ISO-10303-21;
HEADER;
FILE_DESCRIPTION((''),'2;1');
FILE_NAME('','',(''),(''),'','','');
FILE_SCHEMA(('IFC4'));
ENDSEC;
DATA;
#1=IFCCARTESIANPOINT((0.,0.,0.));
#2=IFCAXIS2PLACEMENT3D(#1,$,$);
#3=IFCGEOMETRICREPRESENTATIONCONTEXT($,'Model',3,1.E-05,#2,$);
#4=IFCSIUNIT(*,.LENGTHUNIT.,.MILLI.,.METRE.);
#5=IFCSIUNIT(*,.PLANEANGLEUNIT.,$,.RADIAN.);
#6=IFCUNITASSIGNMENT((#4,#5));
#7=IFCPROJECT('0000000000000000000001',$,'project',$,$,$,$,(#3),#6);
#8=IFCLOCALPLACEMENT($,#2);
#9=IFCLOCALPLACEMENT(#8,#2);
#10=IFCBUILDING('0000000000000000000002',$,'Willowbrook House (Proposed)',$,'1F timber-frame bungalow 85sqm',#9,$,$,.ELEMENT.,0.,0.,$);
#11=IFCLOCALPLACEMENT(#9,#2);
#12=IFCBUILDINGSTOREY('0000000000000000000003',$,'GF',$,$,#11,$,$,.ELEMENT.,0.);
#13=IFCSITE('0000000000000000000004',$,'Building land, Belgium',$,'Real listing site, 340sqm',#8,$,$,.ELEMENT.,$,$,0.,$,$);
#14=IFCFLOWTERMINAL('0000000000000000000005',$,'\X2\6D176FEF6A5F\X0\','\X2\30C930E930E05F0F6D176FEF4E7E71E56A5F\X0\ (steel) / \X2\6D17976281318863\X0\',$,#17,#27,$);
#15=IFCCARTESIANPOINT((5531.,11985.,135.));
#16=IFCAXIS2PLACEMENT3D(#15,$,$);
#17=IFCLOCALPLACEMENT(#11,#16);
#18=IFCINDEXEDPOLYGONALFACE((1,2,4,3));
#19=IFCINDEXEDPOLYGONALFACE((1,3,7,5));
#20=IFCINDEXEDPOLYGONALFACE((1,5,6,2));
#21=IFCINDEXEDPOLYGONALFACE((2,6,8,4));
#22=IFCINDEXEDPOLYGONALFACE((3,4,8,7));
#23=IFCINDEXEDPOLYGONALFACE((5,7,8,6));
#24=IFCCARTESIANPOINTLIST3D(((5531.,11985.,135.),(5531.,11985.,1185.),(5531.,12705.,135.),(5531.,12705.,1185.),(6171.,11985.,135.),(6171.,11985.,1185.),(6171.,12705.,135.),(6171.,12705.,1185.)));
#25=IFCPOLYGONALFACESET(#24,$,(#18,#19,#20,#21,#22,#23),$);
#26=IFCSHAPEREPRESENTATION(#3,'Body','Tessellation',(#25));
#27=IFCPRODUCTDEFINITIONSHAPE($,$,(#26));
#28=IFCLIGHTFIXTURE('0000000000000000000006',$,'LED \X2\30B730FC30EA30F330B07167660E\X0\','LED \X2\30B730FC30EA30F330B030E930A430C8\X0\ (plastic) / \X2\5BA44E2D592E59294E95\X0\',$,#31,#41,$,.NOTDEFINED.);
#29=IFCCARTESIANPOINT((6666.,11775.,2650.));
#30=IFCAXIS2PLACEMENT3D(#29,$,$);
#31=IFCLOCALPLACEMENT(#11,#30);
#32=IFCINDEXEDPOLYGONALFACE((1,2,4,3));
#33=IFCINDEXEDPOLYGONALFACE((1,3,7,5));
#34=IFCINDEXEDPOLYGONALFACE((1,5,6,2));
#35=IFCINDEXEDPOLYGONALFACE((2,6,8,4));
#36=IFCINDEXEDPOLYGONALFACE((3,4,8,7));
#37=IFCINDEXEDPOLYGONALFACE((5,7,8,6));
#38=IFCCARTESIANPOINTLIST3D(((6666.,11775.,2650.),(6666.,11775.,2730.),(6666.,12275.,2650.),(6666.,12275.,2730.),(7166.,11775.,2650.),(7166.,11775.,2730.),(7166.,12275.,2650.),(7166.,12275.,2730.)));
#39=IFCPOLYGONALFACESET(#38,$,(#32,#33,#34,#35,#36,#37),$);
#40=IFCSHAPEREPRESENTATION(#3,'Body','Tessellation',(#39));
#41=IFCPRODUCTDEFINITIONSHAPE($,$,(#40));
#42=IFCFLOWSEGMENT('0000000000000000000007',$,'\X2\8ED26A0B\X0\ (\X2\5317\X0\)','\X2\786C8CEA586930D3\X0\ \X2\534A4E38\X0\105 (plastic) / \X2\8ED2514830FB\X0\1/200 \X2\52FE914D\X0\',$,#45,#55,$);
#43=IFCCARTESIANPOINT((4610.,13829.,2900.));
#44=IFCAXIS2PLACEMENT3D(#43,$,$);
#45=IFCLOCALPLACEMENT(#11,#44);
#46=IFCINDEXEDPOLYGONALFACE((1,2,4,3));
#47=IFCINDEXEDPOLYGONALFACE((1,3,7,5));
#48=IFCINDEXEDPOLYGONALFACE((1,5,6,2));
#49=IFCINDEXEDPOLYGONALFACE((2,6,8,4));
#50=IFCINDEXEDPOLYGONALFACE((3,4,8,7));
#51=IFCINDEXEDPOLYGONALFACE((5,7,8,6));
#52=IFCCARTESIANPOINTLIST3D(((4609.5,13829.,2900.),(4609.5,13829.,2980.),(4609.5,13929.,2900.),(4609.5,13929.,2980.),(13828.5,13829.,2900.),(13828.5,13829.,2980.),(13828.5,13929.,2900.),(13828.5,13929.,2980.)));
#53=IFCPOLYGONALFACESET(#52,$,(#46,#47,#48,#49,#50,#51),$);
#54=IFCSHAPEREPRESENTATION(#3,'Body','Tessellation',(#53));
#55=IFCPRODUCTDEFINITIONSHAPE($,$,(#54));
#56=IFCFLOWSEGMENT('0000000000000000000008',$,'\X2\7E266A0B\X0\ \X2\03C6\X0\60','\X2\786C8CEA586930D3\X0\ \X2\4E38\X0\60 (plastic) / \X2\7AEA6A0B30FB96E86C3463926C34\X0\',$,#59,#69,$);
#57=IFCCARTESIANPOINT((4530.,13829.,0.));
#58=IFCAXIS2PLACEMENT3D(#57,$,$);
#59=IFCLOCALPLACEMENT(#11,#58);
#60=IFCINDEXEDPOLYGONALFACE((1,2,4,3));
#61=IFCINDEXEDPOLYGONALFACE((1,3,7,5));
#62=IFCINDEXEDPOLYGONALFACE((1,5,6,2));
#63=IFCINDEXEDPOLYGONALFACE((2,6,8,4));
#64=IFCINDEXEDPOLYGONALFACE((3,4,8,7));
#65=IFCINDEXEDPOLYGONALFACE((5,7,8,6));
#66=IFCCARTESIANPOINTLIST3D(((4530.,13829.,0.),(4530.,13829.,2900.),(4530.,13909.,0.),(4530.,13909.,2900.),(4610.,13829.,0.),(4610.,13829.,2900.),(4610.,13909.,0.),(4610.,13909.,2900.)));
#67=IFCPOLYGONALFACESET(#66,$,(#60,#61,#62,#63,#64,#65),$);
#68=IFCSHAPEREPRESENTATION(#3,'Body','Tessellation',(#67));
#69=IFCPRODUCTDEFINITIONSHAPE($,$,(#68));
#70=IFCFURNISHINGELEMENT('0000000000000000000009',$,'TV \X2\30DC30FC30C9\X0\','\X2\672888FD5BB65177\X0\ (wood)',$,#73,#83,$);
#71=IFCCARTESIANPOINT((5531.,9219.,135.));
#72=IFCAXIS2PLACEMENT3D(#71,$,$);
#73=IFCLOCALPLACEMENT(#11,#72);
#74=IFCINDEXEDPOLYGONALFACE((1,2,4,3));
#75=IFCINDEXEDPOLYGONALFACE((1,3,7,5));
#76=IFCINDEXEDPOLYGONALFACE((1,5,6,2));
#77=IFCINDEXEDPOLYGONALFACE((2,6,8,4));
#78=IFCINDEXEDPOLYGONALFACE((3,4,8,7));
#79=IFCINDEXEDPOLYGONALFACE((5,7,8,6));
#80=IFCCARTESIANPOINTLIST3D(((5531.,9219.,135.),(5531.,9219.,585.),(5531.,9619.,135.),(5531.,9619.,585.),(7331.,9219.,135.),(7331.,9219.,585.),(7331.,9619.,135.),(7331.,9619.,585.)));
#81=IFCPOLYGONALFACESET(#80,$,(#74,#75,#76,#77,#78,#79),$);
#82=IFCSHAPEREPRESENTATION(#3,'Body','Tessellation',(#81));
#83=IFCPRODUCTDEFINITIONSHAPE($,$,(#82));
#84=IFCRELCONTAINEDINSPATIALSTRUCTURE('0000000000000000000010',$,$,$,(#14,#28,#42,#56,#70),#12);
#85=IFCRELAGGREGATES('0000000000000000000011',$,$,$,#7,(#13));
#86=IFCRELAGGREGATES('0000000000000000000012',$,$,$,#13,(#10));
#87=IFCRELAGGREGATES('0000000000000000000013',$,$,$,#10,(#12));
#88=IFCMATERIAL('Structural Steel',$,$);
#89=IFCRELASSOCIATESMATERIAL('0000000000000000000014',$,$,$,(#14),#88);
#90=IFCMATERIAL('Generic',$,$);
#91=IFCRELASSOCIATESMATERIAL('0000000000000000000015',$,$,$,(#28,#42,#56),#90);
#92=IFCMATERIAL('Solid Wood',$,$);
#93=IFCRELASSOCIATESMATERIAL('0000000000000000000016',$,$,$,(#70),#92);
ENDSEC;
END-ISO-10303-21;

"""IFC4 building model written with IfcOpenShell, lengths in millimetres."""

from ifc_helpers import new_model, si_unit, frame, frame_2d, origin, place, context, project, spatial, rectangle, extrude, material, element, save


model = new_model("IFC4")

# Units and contexts
model_context = context("Model", 3, precision=1e-05, world=origin())
ifc_project = project(units=[si_unit("LENGTHUNIT", "METRE", prefix="MILLI"), si_unit("PLANEANGLEUNIT", "RADIAN")], contexts=[model_context])

# Site, building, storey
site_placement = place(None, origin())
site = spatial("IfcSite", under=ifc_project, at=site_placement, Name="Building land, Belgium", ObjectType="Real listing site, 340sqm", CompositionType="ELEMENT", RefElevation=0.0)
building_placement = place(site_placement, origin())
building = spatial("IfcBuilding", under=site, at=building_placement, Name="Willowbrook House (Proposed)", ObjectType="1F timber-frame bungalow 85sqm", CompositionType="ELEMENT", ElevationOfRefHeight=0.0, ElevationOfTerrain=0.0)
storey_placement = place(building_placement, origin())
storey = spatial("IfcBuildingStorey", under=building, at=storey_placement, Name="GF", CompositionType="ELEMENT", Elevation=0.0)

# Shared definitions
ifc_material_1 = material(Name="Solid Wood")

# Shared definitions
ifc_material_2 = material(Name="Generic")

# Shared definitions
ifc_material_3 = material(Name="Structural Steel")

# Flow terminal
flow_terminal_placement = place(storey_placement, frame((5531.0, 11985.0, 135.0)))
element("IfcFlowTerminal", 1, at=flow_terminal_placement, inside=storey, material=ifc_material_3, Name="洗濯機", Description="ドラム式洗濯乾燥機 (steel) / 洗面脱衣", context=model_context, shape_type="SweptSolid", body=[
    extrude(rectangle(XDim=640.0, YDim=720.0, at=frame_2d((320.0, 360.0))), frame((5531.0, 11985.0, 135.0)), (0.0, 0.0, 1.0), 1050.0),
])

# Light fixture
light_fixture_placement = place(storey_placement, frame((6666.0, 11775.0, 2650.0)))
element("IfcLightFixture", 2, at=light_fixture_placement, inside=storey, material=ifc_material_2, Name="LED シーリング照明", Description="LED シーリングライト (plastic) / 室中央天井", PredefinedType="NOTDEFINED", context=model_context, shape_type="SweptSolid", body=[
    extrude(rectangle(XDim=500.0, YDim=500.0, at=frame_2d((250.0, 250.0))), frame((6666.0, 11775.0, 2650.0)), (0.0, 0.0, 1.0), 80.0),
])

# Flow segments
flow_segment_1_placement = place(storey_placement, frame((4610.0, 13829.0, 2900.0)))
element("IfcFlowSegment", 3, at=flow_segment_1_placement, inside=storey, material=ifc_material_2, Name="軒樋 (北)", Description="硬質塩ビ 半丸105 (plastic) / 軒先・1/200 勾配", context=model_context, shape_type="SweptSolid", body=[
    extrude(rectangle(XDim=9219.0, YDim=100.0, at=frame_2d((4609.0, 50.0))), frame((4610.0, 13829.0, 2900.0)), (0.0, 0.0, 1.0), 80.0),
])
flow_segment_2_placement = place(storey_placement, frame((4530.0, 13829.0, 0.0)))
element("IfcFlowSegment", 4, at=flow_segment_2_placement, inside=storey, material=ifc_material_2, Name="縦樋 φ60", Description="硬質塩ビ 丸60 (plastic) / 竪樋・雨水排水", context=model_context, shape_type="SweptSolid", body=[
    extrude(rectangle(XDim=80.0, YDim=80.0, at=frame_2d((40.0, 40.0))), frame((4530.0, 13829.0, 0.0)), (0.0, 0.0, 1.0), 2900.0),
])

# Furnishing element
furnishing_placement = place(storey_placement, frame((5531.0, 9219.0, 135.0)))
element("IfcFurnishingElement", 5, at=furnishing_placement, inside=storey, material=ifc_material_1, Name="TV ボード", Description="木製家具 (wood)", context=model_context, shape_type="SweptSolid", body=[
    extrude(rectangle(XDim=1800.0, YDim=400.0, at=frame_2d((900.0, 200.0))), frame((5531.0, 9219.0, 135.0)), (0.0, 0.0, 1.0), 450.0),
])

save(model, "model.ifc")
